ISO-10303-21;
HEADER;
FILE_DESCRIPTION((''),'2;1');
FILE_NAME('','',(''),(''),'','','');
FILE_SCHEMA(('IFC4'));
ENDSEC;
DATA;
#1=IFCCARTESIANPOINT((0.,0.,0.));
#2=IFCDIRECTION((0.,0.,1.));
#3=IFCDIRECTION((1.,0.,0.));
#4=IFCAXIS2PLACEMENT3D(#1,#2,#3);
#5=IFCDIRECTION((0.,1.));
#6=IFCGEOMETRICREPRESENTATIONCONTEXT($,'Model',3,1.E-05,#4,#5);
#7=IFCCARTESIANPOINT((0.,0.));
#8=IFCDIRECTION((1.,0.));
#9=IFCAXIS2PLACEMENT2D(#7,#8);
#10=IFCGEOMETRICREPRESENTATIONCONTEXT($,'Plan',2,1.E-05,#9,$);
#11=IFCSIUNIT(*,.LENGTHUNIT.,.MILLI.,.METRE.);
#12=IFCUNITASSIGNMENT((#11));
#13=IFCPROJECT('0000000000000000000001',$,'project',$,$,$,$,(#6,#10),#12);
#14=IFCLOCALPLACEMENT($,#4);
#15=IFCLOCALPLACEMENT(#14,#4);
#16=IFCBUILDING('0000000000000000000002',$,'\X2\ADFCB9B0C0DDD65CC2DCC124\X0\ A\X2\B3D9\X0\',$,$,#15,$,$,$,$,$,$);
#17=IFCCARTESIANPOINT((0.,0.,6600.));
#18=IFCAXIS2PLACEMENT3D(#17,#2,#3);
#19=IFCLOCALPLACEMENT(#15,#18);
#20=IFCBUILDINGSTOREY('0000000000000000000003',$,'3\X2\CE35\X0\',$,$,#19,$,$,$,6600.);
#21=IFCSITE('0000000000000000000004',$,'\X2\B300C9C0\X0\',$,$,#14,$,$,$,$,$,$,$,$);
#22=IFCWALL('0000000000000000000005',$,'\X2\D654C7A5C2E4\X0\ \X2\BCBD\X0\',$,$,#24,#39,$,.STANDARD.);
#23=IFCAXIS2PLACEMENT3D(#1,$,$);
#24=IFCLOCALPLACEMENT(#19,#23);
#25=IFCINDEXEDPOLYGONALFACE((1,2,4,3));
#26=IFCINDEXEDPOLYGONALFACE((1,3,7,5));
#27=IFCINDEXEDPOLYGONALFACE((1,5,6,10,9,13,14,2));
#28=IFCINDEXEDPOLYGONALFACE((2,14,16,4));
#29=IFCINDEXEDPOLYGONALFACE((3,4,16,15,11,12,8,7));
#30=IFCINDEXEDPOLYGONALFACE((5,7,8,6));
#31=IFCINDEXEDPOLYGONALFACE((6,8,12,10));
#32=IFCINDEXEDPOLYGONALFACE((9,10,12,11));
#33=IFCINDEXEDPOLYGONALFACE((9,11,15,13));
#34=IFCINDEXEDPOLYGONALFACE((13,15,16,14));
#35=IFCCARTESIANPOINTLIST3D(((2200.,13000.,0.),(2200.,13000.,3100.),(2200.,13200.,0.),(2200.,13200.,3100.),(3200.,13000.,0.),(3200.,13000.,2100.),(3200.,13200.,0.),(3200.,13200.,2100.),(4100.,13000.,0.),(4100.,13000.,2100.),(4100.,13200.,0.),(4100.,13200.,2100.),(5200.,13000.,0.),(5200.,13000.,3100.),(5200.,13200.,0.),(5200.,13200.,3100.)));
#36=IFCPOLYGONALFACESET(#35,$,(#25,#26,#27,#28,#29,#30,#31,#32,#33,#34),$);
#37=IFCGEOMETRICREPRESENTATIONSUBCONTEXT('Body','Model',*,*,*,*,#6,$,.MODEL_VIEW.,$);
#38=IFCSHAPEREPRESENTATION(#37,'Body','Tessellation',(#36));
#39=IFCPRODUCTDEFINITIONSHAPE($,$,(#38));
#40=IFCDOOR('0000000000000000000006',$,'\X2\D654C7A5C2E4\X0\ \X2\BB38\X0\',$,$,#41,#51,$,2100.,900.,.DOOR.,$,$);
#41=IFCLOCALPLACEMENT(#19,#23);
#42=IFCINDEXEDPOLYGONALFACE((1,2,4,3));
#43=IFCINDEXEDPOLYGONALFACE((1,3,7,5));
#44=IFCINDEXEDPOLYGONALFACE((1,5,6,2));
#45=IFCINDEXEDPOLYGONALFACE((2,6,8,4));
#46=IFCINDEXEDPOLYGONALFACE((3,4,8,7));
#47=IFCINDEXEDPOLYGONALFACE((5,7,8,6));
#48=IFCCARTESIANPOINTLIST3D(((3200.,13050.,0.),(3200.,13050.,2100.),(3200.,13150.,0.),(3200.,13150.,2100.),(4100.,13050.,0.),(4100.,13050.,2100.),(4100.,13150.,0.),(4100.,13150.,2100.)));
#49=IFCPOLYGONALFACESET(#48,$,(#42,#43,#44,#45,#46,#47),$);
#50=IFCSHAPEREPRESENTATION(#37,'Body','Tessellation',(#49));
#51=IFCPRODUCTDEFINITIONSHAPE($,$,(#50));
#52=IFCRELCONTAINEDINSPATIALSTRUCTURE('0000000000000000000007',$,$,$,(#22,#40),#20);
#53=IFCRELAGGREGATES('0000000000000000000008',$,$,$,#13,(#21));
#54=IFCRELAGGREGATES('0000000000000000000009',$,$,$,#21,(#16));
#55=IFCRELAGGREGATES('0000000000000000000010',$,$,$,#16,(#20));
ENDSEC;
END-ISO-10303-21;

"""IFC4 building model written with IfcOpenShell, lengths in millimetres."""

from ifc_helpers import new_model, si_unit, direction, frame, origin_with_axes, origin_2d_with_axis, place, context, subcontext, project, spatial, polyline, outline, extrude, element, fill, save


model = new_model("IFC4")

# Units and contexts
model_context = context("Model", 3, precision=1e-05, world=origin_with_axes(), true_north=direction((0.0, 1.0)))
plan_context = context("Plan", 2, precision=1e-05, world=origin_2d_with_axis())
body_context = subcontext(model_context, "Body", "Model", "MODEL_VIEW")
ifc_project = project(units=[si_unit("LENGTHUNIT", "METRE", prefix="MILLI")], contexts=[model_context, plan_context])

# Site, building, storey
site_placement = place(None, origin_with_axes())
site = spatial("IfcSite", under=ifc_project, at=site_placement, Name="대지")
building_placement = place(site_placement, origin_with_axes())
building = spatial("IfcBuilding", under=site, at=building_placement, Name="근린생활시설 A동")
storey_placement = place(building_placement, frame((0.0, 0.0, 6600.0), z_axis=(0.0, 0.0, 1.0), x_axis=(1.0, 0.0, 0.0)))
storey = spatial("IfcBuildingStorey", under=building, at=storey_placement, Name="3층", Elevation=6600.0)

# Wall, opening, door
wall_1_placement = place(storey_placement, origin_with_axes())
wall_1 = element("IfcWall", 1, at=wall_1_placement, inside=storey, Name="화장실 벽", PredefinedType="STANDARD", context=body_context, shape_type="SweptSolid", body=[
    extrude(outline(polyline([(2200.0, 13200.0), (5200.0, 13200.0), (5200.0, 13000.0), (2200.0, 13000.0), (2200.0, 13200.0)])), origin_with_axes(), (0.0, 0.0, 1.0), 3100.0),
])
opening_1_placement = place(storey_placement, origin_with_axes())
opening_1 = element("IfcOpeningElement", 2, at=opening_1_placement, cuts=wall_1, PredefinedType="OPENING", context=body_context, shape_type="SweptSolid", body=[
    extrude(outline(polyline([(3200.0, 12950.0), (4100.0, 12950.0), (4100.0, 13250.0), (3200.0, 13250.0), (3200.0, 12950.0)])), origin_with_axes(), (0.0, 0.0, 1.0), 2100.0),
])
door_1_placement = place(storey_placement, origin_with_axes())
door_1 = element("IfcDoor", 3, at=door_1_placement, inside=storey, Name="화장실 문", OverallHeight=2100.0, OverallWidth=900.0, PredefinedType="DOOR", context=body_context, shape_type="SweptSolid", body=[
    extrude(outline(polyline([(3200.0, 13050.0), (4100.0, 13050.0), (4100.0, 13150.0), (3200.0, 13150.0), (3200.0, 13050.0)])), origin_with_axes(), (0.0, 0.0, 1.0), 2100.0),
])
fill(opening_1, door_1)

save(model, "model.ifc")
